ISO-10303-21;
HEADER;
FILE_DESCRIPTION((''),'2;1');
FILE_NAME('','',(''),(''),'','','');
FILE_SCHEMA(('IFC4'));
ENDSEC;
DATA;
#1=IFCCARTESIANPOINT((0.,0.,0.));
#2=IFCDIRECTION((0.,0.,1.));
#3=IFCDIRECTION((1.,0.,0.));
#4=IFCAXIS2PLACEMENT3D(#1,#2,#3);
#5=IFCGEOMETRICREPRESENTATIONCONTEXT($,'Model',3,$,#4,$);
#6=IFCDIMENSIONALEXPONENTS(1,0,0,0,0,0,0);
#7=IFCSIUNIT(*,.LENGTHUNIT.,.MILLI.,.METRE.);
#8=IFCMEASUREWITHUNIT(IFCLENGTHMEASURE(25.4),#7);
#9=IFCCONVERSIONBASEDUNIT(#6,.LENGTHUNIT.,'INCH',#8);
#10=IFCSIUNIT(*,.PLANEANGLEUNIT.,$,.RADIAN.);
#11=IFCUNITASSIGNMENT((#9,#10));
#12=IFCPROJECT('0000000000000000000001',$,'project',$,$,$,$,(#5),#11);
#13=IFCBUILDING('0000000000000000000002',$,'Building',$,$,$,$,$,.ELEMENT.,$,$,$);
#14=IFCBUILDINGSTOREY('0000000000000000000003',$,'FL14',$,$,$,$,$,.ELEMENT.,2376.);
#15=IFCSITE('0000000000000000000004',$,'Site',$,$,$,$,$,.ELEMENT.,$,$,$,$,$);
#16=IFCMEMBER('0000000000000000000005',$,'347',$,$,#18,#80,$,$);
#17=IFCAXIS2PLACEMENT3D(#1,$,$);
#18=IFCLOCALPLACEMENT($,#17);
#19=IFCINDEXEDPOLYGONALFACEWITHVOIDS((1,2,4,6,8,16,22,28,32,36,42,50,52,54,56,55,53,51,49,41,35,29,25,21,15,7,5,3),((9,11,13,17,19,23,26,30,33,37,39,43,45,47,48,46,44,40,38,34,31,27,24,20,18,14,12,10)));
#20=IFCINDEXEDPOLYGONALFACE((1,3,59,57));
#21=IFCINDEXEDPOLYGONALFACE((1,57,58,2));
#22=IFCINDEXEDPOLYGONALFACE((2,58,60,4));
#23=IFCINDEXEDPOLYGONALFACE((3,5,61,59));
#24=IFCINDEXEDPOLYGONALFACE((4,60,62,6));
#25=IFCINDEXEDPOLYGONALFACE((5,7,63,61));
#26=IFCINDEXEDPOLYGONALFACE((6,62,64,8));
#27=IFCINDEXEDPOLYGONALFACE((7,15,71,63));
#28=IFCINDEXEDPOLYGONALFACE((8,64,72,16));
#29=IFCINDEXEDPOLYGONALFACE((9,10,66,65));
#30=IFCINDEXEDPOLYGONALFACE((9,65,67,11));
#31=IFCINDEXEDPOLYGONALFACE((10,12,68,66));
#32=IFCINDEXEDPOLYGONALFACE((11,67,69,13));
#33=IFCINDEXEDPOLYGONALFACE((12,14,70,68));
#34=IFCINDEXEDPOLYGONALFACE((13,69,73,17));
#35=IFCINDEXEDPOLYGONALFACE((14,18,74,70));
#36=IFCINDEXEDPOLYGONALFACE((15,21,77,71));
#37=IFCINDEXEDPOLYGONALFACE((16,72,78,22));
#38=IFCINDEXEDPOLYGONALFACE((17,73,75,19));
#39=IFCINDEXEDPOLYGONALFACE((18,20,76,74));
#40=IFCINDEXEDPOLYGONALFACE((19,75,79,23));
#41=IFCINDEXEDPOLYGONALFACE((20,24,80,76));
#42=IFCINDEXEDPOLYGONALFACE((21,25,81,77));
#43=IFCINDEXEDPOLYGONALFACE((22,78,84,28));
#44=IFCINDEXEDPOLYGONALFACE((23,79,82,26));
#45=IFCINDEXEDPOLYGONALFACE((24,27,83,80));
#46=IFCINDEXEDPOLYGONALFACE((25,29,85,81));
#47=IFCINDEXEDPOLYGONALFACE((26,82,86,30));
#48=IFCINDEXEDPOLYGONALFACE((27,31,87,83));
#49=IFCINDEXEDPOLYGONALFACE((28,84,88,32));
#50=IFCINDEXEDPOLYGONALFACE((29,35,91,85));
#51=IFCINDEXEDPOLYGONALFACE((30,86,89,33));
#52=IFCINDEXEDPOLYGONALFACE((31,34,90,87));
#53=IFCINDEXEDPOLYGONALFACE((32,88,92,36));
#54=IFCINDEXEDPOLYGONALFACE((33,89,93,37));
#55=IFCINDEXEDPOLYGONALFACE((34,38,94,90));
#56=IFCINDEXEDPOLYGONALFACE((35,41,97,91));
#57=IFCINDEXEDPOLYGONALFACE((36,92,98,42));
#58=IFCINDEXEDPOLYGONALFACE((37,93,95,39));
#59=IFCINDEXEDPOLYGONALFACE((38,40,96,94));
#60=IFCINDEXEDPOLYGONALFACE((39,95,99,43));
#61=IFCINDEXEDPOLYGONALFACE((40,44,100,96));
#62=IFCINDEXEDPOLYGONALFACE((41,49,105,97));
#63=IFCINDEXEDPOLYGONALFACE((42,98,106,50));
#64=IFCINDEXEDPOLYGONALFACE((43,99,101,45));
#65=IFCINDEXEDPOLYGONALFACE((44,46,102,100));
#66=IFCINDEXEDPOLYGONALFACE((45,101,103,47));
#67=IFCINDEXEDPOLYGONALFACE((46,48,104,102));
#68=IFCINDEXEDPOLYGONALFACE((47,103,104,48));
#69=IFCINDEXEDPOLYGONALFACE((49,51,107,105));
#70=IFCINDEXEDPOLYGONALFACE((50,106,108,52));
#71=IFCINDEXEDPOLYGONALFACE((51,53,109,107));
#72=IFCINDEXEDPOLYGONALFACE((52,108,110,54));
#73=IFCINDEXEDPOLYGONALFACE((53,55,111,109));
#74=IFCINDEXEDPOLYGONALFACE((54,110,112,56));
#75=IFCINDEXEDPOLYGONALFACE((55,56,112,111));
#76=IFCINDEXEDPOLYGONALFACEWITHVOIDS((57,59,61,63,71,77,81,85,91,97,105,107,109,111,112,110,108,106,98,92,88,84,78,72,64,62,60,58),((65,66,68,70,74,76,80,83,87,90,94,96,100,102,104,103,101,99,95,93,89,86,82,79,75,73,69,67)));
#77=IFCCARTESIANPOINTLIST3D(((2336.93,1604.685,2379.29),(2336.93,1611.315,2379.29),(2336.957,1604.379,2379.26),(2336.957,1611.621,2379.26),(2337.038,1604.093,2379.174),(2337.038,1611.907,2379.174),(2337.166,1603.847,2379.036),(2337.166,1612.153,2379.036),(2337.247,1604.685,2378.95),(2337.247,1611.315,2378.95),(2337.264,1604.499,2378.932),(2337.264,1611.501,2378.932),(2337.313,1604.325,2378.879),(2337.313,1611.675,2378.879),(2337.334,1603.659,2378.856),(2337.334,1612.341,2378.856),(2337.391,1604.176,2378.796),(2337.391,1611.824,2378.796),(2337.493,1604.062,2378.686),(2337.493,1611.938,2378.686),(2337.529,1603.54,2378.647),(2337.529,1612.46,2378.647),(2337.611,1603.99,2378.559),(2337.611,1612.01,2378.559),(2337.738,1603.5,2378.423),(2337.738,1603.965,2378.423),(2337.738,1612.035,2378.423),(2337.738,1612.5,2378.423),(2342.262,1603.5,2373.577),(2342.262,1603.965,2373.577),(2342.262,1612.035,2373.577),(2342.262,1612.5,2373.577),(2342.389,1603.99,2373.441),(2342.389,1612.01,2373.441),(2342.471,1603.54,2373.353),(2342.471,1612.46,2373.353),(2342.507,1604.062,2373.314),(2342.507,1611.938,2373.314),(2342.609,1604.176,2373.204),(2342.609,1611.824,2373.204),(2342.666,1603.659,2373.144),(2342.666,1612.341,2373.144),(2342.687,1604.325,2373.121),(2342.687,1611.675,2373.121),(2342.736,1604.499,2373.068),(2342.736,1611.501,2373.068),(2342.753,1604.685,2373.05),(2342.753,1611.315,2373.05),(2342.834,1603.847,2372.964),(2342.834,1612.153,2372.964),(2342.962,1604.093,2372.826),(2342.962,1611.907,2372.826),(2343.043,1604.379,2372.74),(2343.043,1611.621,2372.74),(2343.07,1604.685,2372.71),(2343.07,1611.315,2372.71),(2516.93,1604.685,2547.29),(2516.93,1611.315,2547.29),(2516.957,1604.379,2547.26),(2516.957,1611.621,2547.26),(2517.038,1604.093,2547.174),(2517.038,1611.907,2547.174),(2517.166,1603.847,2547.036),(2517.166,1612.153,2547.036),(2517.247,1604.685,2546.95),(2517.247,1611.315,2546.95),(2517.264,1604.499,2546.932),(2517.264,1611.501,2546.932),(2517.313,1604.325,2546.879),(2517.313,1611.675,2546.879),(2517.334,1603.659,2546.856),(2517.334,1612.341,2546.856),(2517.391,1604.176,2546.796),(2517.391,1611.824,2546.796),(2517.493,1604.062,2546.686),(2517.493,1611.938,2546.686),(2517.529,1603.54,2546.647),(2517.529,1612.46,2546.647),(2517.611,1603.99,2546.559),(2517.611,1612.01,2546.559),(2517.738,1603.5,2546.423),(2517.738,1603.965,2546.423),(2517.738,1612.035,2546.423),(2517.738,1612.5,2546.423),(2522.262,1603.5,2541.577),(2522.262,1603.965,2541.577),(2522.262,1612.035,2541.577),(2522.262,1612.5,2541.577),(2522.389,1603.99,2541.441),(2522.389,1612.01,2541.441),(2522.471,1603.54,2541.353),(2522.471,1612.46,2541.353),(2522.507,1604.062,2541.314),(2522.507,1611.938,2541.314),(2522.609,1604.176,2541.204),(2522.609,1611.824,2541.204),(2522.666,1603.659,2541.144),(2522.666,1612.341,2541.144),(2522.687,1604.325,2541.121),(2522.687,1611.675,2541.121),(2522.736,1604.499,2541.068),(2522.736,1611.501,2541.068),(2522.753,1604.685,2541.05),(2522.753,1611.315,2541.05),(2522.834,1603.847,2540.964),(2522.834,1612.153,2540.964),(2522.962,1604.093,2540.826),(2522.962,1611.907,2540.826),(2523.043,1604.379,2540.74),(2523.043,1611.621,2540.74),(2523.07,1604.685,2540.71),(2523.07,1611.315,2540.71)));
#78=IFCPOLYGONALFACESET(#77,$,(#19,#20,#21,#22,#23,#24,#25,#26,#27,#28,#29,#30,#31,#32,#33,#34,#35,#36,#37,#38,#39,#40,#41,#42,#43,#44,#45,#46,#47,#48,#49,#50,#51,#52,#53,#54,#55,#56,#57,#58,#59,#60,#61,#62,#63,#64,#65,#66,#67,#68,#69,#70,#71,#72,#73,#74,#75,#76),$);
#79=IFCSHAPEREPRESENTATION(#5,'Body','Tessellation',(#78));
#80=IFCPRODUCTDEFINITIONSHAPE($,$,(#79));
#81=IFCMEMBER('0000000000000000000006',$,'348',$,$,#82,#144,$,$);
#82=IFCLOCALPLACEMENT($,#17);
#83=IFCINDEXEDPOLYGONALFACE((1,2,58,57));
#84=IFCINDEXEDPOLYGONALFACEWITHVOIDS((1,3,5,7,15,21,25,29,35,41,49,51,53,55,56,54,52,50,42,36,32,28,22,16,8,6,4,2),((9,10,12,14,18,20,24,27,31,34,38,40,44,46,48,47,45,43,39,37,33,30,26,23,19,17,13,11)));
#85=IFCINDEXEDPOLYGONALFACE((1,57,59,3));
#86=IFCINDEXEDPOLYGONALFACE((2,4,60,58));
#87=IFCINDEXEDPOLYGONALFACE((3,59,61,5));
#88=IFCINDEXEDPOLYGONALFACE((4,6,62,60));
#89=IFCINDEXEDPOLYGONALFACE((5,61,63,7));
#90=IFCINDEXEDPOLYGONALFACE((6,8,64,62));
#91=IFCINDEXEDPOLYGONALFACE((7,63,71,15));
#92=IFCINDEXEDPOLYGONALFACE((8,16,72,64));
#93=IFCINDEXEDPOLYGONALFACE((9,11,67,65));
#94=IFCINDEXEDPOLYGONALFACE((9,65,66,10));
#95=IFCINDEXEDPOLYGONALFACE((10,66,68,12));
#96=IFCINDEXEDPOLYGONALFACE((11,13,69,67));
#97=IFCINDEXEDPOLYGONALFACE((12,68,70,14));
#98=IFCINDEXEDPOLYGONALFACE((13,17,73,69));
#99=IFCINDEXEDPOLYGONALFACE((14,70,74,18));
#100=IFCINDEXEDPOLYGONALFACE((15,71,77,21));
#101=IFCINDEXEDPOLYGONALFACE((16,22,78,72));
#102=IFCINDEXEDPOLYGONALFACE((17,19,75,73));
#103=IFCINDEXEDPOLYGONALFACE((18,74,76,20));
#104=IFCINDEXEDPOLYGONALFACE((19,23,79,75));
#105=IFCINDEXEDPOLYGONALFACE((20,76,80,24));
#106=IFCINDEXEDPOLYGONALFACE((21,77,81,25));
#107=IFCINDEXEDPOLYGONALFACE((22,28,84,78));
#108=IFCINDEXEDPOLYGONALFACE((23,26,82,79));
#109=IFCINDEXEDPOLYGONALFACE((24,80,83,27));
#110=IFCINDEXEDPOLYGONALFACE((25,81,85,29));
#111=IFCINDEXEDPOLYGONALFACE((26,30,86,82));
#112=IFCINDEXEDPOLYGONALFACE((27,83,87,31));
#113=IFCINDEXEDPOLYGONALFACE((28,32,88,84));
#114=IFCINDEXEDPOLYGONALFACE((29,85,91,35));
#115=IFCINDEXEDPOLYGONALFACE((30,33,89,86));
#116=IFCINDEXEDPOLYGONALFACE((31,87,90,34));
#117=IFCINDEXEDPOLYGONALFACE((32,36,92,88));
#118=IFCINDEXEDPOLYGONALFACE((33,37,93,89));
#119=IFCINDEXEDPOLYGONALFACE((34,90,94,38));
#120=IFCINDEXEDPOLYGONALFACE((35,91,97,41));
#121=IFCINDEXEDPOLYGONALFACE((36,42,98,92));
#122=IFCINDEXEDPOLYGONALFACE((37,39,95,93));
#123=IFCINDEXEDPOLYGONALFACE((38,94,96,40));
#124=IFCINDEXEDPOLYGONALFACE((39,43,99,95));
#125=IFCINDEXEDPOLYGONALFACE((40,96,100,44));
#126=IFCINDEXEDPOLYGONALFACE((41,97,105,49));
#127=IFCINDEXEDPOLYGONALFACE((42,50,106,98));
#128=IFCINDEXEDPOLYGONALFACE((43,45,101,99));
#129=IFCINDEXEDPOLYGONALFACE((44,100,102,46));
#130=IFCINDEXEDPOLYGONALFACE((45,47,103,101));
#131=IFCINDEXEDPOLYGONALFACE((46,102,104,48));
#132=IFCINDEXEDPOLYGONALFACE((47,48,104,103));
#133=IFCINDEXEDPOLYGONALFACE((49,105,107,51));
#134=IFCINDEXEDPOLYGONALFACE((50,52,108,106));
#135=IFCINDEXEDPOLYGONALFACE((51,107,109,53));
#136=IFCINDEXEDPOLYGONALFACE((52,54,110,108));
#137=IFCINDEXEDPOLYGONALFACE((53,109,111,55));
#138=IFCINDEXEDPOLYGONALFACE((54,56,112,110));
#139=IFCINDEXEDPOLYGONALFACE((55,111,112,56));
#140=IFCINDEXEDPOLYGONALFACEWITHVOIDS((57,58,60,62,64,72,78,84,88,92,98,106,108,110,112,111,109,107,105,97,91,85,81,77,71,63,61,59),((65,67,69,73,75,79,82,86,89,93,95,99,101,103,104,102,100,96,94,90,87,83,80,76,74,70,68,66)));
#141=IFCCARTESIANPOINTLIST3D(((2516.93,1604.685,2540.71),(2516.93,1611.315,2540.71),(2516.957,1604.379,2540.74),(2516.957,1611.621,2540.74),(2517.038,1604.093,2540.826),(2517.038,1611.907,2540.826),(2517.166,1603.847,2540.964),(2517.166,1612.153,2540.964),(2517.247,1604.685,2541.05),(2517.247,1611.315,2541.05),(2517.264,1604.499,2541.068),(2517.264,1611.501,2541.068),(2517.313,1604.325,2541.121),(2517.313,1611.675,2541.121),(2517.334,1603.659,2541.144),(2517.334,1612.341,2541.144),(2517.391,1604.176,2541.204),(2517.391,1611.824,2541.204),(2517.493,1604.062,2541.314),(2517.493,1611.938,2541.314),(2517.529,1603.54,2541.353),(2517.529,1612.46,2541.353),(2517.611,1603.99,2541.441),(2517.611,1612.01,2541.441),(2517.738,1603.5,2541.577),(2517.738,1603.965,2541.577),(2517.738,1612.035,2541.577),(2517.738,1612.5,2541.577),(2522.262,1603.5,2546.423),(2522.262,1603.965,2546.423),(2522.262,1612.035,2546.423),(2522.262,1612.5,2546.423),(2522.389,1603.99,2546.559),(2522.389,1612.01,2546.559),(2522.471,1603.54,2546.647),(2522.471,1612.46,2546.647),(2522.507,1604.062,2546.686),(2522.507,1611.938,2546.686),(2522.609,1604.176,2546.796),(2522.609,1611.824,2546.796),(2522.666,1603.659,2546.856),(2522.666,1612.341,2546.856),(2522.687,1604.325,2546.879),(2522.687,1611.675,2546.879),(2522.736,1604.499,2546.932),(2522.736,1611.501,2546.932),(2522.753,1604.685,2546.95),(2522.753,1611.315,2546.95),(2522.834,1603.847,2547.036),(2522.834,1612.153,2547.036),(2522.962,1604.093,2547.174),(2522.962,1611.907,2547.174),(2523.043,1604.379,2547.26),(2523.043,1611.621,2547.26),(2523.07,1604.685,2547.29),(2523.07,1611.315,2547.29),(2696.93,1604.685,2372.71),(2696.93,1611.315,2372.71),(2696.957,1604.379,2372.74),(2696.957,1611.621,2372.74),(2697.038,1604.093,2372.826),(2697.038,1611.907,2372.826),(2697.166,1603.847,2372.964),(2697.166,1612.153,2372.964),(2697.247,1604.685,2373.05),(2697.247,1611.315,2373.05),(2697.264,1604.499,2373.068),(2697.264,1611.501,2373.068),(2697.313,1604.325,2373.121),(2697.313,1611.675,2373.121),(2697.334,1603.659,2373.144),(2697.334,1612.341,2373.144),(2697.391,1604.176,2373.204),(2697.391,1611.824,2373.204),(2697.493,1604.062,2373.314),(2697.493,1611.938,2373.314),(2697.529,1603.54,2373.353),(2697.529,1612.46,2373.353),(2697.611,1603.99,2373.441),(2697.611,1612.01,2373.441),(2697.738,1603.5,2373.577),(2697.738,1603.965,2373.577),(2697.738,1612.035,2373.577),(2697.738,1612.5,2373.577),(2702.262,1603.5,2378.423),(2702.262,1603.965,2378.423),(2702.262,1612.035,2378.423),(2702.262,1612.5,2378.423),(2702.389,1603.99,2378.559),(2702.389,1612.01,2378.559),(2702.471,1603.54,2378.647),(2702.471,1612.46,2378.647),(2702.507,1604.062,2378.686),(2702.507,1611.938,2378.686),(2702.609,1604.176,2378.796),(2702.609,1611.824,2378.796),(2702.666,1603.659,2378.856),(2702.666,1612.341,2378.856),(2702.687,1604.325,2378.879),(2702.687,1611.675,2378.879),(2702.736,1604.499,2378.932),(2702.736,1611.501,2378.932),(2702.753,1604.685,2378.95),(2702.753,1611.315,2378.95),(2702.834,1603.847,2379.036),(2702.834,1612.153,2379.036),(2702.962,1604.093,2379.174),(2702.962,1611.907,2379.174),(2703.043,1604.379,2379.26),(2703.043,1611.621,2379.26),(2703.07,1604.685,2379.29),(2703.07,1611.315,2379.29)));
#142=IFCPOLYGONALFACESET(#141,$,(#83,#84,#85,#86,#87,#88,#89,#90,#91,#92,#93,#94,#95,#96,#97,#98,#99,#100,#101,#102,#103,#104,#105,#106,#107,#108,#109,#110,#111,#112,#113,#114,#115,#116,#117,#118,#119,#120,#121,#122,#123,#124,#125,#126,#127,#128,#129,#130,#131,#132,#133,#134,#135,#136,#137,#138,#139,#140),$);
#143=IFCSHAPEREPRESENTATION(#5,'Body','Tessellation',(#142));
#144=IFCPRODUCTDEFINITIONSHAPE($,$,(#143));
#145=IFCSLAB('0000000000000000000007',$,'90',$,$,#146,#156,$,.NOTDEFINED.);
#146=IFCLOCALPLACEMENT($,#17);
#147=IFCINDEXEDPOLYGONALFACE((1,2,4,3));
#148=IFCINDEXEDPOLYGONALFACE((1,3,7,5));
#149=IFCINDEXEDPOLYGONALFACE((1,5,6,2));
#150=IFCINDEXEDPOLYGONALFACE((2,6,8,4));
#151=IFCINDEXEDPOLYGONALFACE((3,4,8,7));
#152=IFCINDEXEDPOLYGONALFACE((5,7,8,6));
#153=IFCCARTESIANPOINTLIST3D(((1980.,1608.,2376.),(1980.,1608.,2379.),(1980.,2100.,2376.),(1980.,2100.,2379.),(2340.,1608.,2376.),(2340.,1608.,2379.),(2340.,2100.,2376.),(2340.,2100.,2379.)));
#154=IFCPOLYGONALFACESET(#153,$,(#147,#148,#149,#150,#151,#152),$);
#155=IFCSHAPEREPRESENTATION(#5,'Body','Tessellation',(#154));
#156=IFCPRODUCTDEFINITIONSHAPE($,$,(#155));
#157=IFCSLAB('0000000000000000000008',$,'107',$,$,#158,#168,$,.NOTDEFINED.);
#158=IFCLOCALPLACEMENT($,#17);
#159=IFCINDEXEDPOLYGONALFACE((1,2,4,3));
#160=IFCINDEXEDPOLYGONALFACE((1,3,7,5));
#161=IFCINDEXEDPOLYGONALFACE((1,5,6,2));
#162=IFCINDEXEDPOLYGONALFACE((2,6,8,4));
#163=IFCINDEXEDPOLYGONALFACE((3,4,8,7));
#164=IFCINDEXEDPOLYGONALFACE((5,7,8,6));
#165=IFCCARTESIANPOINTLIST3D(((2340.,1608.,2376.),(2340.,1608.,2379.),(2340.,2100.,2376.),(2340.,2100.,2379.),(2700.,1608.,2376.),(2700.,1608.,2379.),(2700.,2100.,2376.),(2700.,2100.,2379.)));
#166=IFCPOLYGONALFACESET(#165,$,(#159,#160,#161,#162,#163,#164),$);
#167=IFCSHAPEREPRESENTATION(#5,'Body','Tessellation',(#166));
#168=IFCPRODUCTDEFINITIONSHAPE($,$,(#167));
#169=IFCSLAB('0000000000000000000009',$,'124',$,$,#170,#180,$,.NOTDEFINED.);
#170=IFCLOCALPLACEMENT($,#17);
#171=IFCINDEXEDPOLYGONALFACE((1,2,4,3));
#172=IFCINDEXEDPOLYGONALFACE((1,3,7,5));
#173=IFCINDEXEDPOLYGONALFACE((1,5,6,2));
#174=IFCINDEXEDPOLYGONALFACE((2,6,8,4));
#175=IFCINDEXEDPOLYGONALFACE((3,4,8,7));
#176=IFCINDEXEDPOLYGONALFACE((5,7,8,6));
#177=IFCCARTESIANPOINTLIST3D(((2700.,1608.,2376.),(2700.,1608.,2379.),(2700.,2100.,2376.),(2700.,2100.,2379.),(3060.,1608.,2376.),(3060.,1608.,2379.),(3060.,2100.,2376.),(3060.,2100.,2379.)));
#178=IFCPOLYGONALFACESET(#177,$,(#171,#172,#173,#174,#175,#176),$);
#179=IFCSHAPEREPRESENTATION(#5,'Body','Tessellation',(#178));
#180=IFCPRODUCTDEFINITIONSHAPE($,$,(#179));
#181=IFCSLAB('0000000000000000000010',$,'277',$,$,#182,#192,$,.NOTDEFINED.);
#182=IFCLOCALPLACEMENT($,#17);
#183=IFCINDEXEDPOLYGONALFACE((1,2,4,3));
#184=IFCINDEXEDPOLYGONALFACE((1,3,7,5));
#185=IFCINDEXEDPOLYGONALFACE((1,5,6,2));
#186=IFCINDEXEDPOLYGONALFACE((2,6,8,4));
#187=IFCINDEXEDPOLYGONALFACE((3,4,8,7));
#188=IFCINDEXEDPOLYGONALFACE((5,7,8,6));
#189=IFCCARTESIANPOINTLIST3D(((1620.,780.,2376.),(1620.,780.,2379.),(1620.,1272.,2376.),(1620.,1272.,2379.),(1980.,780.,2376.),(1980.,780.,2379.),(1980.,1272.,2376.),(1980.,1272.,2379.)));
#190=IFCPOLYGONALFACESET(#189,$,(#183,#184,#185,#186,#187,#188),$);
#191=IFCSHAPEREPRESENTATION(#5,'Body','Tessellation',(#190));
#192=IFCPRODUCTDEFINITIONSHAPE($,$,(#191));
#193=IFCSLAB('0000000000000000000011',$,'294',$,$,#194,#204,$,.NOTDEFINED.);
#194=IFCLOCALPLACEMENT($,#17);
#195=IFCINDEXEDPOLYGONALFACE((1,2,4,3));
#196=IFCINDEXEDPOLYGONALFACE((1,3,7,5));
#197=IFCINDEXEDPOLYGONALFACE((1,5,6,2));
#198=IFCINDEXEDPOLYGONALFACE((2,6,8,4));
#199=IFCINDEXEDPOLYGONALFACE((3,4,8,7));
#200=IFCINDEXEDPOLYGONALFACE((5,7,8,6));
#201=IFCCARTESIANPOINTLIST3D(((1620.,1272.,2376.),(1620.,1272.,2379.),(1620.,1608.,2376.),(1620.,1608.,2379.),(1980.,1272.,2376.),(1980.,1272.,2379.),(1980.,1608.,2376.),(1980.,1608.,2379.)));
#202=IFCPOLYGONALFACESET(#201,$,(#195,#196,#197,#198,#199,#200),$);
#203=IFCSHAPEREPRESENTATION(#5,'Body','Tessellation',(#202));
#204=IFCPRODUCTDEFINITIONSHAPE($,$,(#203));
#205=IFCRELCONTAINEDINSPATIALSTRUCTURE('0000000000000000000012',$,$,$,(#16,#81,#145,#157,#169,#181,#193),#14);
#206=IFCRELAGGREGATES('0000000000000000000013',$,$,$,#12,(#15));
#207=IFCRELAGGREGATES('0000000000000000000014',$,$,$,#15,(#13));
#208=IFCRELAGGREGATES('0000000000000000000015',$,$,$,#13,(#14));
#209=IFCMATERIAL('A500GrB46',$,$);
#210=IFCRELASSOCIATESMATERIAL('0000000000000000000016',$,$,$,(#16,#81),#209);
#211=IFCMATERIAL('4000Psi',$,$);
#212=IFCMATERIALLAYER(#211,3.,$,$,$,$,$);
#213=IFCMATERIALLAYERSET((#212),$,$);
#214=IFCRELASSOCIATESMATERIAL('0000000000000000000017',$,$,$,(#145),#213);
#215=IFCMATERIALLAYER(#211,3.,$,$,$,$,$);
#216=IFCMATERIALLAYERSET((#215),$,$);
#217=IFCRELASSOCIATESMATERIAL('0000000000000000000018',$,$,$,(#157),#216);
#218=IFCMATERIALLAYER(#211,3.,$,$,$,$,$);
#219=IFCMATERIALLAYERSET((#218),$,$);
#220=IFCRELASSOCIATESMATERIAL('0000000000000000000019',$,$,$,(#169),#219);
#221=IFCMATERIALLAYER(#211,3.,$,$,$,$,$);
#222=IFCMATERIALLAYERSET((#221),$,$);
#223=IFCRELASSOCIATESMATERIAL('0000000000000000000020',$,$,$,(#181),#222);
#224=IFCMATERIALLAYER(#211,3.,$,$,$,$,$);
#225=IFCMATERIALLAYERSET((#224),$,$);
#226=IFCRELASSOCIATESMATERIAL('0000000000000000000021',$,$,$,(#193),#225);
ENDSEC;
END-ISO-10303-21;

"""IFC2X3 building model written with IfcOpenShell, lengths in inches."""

from ifc_helpers import new_model, entity, si_unit, converted_unit, frame, origin_with_axes, origin_2d_with_axis, place, context, project, spatial, polyline, hollow_rectangle, outline, extrude, material, layer, layer_set, layer_usage, element, save


model = new_model("IFC2X3")

# Units and contexts
model_context = context("Model", 3, world=origin_with_axes())
ifc_project = project(units=[converted_unit("LENGTHUNIT", "INCH", entity("IfcLengthMeasure", 25.4), si_unit("LENGTHUNIT", "METRE", prefix="MILLI"), dimensions=[1, 0, 0, 0, 0, 0, 0]), si_unit("PLANEANGLEUNIT", "RADIAN")], contexts=[model_context])

# Site, building, storey
site = spatial("IfcSite", under=ifc_project, Name="Site", CompositionType="ELEMENT")
building = spatial("IfcBuilding", under=site, Name="Building", CompositionType="ELEMENT")
storey = spatial("IfcBuildingStorey", under=building, Name="FL14", CompositionType="ELEMENT", Elevation=2376.0)

# Members
ifc_material_1 = material(Name="A500GrB46")
for number, where, z_axis, x_axis, name in (
    (1, (2340.0, 1608.0, 2376.0), (0.731055, 0.0, 0.682318), (0.0, 1.0, 0.0), "347"),
    (2, (2700.0, 1608.0, 2376.0), (-0.731055, 0.0, 0.682318), (0.0, -1.0, 0.0), "348"),
):
    element("IfcMember", number, at=place(None, frame(where, z_axis=z_axis, x_axis=x_axis)), inside=storey, material=ifc_material_1, Name=name, context=model_context, shape_type="SweptSolid", body=[
        extrude(hollow_rectangle(XDim=9.0, YDim=9.0, WallThickness=0.465, InnerFilletRadius=0.72, OuterFilletRadius=1.185, at=origin_2d_with_axis()), origin_with_axes(), (0.0, 0.0, 1.0), 246.219),
    ])

# Slabs
ifc_material_2 = material(Name="4000Psi")
ifc_layer_1 = layer(ifc_material_2, 3.0)
ifc_layer_set_1 = layer_set([ifc_layer_1])
ifc_layer_usage_1 = layer_usage(ifc_layer_set_1, "AXIS2", "POSITIVE", -3.0)
slab_1_placement = place(None, frame((1980.0, 1608.0, 2376.0), z_axis=(0.0, 0.0, 1.0), x_axis=(1.0, 0.0, 0.0)))
element("IfcSlab", 3, at=slab_1_placement, inside=storey, material=ifc_layer_usage_1, Name="90", PredefinedType="NOTDEFINED", context=model_context, shape_type="SweptSolid", body=[
    extrude(outline(polyline([(0.0, 0.0), (360.0, 0.0), (360.0, 492.0), (0.0, 492.0), (0.0, 0.0)])), origin_with_axes(), (0.0, 0.0, 1.0), 3.0),
])
ifc_layer_2 = layer(ifc_material_2, 3.0)
ifc_layer_set_2 = layer_set([ifc_layer_2])
ifc_layer_usage_2 = layer_usage(ifc_layer_set_2, "AXIS2", "POSITIVE", -3.0)
slab_2_placement = place(None, frame((2340.0, 1608.0, 2376.0), z_axis=(0.0, 0.0, 1.0), x_axis=(1.0, 0.0, 0.0)))
element("IfcSlab", 4, at=slab_2_placement, inside=storey, material=ifc_layer_usage_2, Name="107", PredefinedType="NOTDEFINED", context=model_context, shape_type="SweptSolid", body=[
    extrude(outline(polyline([(0.0, 0.0), (360.0, 0.0), (360.0, 492.0), (0.0, 492.0), (0.0, 0.0)])), origin_with_axes(), (0.0, 0.0, 1.0), 3.0),
])
ifc_layer_3 = layer(ifc_material_2, 3.0)
ifc_layer_set_3 = layer_set([ifc_layer_3])
ifc_layer_usage_3 = layer_usage(ifc_layer_set_3, "AXIS2", "POSITIVE", -3.0)
slab_3_placement = place(None, frame((2700.0, 1608.0, 2376.0), z_axis=(0.0, 0.0, 1.0), x_axis=(1.0, 0.0, 0.0)))
element("IfcSlab", 5, at=slab_3_placement, inside=storey, material=ifc_layer_usage_3, Name="124", PredefinedType="NOTDEFINED", context=model_context, shape_type="SweptSolid", body=[
    extrude(outline(polyline([(0.0, 0.0), (360.0, 0.0), (360.0, 492.0), (0.0, 492.0), (0.0, 0.0)])), origin_with_axes(), (0.0, 0.0, 1.0), 3.0),
])
ifc_layer_4 = layer(ifc_material_2, 3.0)
ifc_layer_set_4 = layer_set([ifc_layer_4])
ifc_layer_usage_4 = layer_usage(ifc_layer_set_4, "AXIS2", "POSITIVE", -3.0)
slab_4_placement = place(None, frame((1620.0, 780.0, 2376.0), z_axis=(0.0, 0.0, 1.0), x_axis=(1.0, 0.0, 0.0)))
element("IfcSlab", 6, at=slab_4_placement, inside=storey, material=ifc_layer_usage_4, Name="277", PredefinedType="NOTDEFINED", context=model_context, shape_type="SweptSolid", body=[
    extrude(outline(polyline([(0.0, 0.0), (360.0, 0.0), (360.0, 492.0), (0.0, 492.0), (0.0, 0.0)])), origin_with_axes(), (0.0, 0.0, 1.0), 3.0),
])
ifc_layer_5 = layer(ifc_material_2, 3.0)
ifc_layer_set_5 = layer_set([ifc_layer_5])
ifc_layer_usage_5 = layer_usage(ifc_layer_set_5, "AXIS2", "POSITIVE", -3.0)
slab_5_placement = place(None, frame((1620.0, 1272.0, 2376.0), z_axis=(0.0, 0.0, 1.0), x_axis=(1.0, 0.0, 0.0)))
element("IfcSlab", 7, at=slab_5_placement, inside=storey, material=ifc_layer_usage_5, Name="294", PredefinedType="NOTDEFINED", context=model_context, shape_type="SweptSolid", body=[
    extrude(outline(polyline([(0.0, 0.0), (360.0, 0.0), (360.0, 336.0), (0.0, 336.0), (0.0, 0.0)])), origin_with_axes(), (0.0, 0.0, 1.0), 3.0),
])

save(model, "model.ifc")
